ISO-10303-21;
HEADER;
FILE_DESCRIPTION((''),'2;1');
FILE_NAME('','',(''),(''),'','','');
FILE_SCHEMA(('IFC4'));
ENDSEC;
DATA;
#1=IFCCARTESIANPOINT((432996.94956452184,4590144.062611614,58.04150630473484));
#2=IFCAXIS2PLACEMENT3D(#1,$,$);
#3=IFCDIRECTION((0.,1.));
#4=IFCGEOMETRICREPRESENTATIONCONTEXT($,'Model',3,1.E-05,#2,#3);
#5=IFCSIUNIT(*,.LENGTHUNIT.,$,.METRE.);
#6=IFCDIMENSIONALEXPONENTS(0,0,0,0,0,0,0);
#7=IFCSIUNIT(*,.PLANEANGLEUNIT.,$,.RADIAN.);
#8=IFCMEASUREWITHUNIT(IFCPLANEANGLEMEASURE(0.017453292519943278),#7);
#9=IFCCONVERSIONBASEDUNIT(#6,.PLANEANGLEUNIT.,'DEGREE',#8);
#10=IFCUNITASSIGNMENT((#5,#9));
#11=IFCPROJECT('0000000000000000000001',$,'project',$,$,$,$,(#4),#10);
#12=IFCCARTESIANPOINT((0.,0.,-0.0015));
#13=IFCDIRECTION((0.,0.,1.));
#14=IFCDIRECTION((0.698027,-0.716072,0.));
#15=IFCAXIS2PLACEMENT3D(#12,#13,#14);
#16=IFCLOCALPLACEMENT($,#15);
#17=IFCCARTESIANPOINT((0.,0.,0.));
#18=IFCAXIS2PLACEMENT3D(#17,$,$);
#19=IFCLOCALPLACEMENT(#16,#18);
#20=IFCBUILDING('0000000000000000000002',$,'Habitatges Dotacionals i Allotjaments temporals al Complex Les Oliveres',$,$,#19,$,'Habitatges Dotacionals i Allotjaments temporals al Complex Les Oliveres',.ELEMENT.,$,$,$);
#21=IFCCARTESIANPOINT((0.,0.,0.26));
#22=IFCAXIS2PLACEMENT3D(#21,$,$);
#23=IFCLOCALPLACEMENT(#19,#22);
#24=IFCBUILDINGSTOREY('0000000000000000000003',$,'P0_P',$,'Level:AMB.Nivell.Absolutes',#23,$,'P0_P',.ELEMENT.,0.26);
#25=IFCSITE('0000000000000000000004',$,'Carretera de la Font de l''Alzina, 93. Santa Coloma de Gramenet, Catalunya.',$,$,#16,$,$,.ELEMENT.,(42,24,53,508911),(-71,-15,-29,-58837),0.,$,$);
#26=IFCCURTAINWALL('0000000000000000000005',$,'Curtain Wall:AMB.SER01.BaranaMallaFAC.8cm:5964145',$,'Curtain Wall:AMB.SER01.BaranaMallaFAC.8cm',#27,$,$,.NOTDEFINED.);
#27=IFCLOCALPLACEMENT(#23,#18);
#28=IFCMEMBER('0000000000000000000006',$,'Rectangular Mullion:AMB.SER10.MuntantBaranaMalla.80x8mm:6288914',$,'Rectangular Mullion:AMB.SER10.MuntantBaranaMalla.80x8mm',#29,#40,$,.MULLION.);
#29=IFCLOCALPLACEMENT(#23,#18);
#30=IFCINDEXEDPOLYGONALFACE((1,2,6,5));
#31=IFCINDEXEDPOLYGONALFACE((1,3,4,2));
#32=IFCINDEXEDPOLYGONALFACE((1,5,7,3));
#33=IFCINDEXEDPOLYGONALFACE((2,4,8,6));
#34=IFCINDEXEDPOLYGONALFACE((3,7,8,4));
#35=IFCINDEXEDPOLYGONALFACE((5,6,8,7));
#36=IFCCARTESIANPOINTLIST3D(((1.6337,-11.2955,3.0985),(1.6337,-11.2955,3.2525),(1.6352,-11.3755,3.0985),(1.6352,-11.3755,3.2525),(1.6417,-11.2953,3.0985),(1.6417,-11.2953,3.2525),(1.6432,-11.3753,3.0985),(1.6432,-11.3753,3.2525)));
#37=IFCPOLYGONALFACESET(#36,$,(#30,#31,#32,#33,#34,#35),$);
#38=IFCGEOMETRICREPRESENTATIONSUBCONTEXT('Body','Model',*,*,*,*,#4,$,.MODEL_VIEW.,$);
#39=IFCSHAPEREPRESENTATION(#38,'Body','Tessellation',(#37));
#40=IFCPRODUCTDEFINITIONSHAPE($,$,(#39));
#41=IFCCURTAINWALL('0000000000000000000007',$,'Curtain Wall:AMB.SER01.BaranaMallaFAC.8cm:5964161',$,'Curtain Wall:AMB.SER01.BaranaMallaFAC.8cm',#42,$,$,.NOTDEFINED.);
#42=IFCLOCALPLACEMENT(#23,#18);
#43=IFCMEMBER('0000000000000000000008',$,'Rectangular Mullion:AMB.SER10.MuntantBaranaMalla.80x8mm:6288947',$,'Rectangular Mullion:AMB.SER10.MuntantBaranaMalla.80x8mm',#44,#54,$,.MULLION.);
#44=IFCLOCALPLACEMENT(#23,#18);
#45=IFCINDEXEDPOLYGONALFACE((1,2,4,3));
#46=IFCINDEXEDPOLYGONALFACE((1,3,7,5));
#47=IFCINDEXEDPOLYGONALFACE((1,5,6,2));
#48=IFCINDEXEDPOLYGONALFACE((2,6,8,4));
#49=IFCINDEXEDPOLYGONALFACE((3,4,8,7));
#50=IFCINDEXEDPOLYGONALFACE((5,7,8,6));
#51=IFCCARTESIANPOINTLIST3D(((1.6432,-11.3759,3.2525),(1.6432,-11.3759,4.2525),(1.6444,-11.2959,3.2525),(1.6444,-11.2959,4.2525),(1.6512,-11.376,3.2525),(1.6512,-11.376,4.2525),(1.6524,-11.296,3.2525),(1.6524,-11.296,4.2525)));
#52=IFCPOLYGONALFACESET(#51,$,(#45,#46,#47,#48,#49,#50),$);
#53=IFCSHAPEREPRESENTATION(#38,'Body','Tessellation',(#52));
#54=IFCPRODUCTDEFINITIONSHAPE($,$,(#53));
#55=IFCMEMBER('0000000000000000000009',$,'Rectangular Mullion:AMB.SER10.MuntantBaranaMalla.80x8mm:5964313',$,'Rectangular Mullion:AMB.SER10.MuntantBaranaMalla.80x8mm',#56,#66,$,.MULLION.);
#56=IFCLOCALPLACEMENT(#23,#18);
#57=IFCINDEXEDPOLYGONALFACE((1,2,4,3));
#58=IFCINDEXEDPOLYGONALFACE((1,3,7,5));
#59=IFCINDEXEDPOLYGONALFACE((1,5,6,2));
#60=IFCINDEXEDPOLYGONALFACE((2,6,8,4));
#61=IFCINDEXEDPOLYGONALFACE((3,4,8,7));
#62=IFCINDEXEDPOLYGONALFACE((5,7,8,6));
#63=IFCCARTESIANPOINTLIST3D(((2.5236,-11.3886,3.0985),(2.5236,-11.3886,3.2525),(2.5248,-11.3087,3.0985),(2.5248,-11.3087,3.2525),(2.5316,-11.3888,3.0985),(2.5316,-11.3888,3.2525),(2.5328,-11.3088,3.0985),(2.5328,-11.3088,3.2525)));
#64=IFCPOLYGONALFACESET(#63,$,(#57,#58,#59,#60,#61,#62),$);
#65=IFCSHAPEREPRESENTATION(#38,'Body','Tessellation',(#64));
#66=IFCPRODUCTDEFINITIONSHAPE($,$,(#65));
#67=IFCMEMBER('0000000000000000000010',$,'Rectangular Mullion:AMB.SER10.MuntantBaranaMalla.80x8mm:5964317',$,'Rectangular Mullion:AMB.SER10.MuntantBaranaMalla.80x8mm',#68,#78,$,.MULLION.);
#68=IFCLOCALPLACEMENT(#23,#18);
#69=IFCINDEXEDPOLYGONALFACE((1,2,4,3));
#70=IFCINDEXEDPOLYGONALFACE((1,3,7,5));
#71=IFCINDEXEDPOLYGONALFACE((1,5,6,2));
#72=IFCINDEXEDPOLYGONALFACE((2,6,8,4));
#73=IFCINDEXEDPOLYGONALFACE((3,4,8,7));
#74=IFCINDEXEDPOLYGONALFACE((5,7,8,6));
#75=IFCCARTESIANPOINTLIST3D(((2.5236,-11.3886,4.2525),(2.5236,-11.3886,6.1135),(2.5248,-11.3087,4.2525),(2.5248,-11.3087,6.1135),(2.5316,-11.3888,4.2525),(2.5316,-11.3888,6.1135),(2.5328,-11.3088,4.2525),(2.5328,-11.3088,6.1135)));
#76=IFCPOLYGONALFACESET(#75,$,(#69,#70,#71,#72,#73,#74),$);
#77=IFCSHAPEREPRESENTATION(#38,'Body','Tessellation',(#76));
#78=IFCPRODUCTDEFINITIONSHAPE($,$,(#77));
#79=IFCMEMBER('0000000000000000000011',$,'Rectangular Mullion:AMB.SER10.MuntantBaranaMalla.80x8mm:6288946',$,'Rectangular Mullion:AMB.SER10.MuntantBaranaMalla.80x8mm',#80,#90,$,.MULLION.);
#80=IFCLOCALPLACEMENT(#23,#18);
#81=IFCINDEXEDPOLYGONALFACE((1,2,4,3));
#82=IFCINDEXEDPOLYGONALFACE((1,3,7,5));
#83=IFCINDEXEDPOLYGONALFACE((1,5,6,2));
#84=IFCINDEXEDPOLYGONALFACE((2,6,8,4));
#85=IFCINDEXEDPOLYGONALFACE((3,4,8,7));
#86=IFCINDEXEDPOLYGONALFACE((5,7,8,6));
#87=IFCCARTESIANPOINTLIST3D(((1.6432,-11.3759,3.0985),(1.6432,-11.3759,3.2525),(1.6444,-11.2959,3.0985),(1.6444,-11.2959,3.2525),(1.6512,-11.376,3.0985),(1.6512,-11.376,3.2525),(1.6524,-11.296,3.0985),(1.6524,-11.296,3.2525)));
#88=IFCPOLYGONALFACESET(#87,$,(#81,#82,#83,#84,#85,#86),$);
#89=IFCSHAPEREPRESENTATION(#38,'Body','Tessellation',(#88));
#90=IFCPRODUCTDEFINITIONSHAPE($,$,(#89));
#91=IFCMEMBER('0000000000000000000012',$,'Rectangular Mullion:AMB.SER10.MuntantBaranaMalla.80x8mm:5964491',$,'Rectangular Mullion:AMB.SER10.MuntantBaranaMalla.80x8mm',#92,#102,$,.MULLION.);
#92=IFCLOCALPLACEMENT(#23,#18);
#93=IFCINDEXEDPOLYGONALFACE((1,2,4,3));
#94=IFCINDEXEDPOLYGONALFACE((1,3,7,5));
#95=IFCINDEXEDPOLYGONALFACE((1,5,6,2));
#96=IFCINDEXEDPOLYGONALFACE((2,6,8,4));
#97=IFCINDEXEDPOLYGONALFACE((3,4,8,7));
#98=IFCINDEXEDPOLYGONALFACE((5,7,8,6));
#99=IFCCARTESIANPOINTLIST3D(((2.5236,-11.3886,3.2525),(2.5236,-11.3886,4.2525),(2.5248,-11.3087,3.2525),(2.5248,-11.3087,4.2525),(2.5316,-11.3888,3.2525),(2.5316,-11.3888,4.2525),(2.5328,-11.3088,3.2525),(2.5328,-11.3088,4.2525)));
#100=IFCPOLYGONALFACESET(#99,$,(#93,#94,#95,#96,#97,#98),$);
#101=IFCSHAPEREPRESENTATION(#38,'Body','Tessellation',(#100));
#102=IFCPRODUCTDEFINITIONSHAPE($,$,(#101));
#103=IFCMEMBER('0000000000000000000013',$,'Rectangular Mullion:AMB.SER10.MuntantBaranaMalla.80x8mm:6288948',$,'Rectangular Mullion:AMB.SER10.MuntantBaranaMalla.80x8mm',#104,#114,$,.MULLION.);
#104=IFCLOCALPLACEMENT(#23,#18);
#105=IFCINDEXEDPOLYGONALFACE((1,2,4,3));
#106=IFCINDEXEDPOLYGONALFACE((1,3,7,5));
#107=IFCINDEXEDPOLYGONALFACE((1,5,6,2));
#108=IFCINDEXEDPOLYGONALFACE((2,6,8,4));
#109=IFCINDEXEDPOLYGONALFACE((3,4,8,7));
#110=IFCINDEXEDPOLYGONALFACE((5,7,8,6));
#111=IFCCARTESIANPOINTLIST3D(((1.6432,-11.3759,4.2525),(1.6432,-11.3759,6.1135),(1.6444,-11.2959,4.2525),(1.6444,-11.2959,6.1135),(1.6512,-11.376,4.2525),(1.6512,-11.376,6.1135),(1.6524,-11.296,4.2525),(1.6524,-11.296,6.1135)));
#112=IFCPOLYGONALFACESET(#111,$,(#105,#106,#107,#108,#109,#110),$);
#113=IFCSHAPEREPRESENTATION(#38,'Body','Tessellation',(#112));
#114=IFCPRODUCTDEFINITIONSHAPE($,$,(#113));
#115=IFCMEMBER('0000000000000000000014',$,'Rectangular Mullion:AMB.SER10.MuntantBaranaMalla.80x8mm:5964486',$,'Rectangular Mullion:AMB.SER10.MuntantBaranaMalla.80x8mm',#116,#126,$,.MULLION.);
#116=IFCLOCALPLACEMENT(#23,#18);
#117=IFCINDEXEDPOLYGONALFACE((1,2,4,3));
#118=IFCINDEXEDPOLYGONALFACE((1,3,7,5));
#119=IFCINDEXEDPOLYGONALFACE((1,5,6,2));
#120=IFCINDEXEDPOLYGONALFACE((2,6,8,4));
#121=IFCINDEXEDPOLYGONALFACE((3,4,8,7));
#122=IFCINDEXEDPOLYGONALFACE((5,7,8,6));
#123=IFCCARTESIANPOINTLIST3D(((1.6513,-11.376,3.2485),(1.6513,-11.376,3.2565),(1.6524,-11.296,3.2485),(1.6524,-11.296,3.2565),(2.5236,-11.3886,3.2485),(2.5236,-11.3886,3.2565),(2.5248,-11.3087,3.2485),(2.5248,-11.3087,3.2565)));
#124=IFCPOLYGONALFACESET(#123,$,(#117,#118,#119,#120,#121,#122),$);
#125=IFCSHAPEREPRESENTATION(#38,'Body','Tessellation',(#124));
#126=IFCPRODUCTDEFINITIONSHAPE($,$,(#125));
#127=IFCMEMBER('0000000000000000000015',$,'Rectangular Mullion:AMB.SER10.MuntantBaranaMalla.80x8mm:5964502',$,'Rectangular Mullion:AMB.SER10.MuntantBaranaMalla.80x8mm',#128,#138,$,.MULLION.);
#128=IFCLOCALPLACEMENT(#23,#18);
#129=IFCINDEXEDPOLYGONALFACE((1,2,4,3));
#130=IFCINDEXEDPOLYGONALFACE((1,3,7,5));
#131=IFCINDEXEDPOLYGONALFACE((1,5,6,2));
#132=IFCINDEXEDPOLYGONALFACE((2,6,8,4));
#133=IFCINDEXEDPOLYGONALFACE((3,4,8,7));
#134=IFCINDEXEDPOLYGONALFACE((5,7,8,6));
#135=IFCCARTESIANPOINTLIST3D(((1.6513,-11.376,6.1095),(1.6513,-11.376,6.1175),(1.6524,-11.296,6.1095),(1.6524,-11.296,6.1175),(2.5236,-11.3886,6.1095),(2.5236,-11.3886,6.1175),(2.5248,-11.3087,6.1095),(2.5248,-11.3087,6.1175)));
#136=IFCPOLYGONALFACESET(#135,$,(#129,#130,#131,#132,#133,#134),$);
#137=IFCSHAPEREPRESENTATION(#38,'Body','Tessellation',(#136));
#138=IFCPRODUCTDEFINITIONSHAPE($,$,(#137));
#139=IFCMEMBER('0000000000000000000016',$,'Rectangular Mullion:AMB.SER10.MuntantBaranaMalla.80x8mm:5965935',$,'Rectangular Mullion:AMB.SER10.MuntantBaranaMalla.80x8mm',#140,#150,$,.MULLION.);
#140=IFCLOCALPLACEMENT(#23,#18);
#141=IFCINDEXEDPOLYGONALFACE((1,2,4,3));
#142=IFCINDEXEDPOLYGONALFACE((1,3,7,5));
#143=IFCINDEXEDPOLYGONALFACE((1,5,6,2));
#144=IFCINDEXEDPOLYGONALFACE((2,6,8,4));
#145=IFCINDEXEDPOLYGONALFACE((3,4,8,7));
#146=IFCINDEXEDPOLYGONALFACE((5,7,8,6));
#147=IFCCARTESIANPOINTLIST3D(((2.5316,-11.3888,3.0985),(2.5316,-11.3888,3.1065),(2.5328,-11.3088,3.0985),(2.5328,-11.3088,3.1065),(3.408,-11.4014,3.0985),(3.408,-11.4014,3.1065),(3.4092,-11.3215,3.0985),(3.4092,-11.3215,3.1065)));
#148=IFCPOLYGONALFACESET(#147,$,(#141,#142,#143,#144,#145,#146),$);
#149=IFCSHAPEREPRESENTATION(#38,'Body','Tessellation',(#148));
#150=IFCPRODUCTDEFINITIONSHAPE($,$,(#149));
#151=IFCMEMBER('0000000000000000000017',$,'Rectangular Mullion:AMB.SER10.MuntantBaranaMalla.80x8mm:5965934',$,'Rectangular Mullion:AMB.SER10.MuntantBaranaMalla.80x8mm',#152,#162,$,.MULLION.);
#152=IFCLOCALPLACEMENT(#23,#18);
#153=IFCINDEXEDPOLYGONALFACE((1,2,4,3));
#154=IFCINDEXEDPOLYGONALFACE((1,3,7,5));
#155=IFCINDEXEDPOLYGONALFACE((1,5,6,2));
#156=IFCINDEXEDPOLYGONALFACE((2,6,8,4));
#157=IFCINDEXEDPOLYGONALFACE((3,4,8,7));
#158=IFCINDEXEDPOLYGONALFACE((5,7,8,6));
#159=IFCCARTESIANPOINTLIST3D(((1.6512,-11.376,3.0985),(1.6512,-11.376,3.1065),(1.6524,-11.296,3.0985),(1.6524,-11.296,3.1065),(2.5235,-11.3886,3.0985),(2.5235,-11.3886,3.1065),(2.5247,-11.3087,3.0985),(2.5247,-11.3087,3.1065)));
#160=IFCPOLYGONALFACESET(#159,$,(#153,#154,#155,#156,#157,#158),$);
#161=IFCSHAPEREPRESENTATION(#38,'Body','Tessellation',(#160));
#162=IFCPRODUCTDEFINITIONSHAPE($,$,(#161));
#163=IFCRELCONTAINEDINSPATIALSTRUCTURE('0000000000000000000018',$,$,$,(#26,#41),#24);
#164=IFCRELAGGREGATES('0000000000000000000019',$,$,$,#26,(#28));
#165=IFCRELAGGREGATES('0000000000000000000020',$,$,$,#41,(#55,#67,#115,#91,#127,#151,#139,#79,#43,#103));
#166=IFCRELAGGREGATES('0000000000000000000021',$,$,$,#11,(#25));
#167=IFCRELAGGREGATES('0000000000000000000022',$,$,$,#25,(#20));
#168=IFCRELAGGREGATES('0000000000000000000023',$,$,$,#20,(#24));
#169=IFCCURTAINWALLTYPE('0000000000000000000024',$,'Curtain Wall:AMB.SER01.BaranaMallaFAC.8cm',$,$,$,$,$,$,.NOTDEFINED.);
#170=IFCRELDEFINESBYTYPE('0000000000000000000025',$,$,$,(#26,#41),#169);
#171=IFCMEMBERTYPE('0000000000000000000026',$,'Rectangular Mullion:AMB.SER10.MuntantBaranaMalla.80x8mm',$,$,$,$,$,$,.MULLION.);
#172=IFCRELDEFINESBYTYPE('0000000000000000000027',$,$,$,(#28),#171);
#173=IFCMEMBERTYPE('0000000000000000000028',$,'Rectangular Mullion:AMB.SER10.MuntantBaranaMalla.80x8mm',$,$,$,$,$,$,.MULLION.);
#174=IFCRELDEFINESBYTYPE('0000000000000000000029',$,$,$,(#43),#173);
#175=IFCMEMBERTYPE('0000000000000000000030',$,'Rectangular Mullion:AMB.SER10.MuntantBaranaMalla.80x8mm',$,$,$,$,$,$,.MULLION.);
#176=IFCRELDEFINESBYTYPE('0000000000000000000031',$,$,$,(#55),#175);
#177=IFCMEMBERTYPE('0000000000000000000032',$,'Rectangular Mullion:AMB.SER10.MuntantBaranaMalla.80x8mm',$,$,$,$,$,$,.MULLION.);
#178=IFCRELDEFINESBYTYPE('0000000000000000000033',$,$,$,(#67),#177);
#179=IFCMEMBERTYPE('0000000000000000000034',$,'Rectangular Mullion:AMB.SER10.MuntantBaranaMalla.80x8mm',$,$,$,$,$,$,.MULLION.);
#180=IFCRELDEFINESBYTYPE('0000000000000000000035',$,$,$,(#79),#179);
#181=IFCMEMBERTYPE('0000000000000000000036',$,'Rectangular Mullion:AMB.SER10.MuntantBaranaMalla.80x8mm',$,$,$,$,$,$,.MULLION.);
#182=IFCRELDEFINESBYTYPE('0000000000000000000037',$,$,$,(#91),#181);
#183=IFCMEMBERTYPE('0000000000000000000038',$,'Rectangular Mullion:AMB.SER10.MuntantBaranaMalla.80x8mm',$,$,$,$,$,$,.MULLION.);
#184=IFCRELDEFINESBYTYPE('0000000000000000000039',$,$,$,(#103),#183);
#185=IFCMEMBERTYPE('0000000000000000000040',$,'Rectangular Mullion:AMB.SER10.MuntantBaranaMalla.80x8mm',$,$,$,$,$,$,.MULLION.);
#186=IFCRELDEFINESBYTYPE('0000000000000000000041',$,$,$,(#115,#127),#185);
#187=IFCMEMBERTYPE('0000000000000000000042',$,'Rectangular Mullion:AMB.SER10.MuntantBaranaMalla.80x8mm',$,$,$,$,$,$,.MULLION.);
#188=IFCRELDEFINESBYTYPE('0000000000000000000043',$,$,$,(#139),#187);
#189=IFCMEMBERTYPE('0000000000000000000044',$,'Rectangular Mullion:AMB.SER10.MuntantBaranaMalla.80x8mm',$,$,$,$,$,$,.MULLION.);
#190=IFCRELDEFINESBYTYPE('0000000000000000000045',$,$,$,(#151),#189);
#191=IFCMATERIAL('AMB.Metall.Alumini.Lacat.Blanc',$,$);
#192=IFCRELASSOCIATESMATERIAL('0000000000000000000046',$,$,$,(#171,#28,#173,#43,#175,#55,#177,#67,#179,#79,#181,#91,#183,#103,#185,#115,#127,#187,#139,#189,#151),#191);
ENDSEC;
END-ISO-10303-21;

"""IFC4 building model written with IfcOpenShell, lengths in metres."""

from ifc_helpers import new_model, entity, si_unit, converted_unit, direction, frame, origin, place, context, subcontext, project, spatial, indexed_curve, outline, extrude, source, transform, mapped, material, type_object, type_shapes, element, aggregate, save


model = new_model("IFC4")

# Units and contexts
model_context = context("Model", 3, precision=1e-05, world=frame((432996.94956452184, 4590144.062611614, 58.04150630473484)), true_north=direction((0.0, 1.0)))
body_context = subcontext(model_context, "Body", "Model", "MODEL_VIEW")
ifc_project = project(units=[si_unit("LENGTHUNIT", "METRE"), converted_unit("PLANEANGLEUNIT", "DEGREE", entity("IfcPlaneAngleMeasure", 0.017453292519943278), si_unit("PLANEANGLEUNIT", "RADIAN"), dimensions=[0, 0, 0, 0, 0, 0, 0])], contexts=[model_context])

# Site, building, storey
site_placement = place(None, frame((0.0, 0.0, -0.0015), z_axis=(0.0, 0.0, 1.0), x_axis=(0.698027, -0.716072, 0.0)))
site = spatial("IfcSite", under=ifc_project, at=site_placement, Name="Carretera de la Font de l'Alzina, 93. Santa Coloma de Gramenet, Catalunya.", CompositionType="ELEMENT", RefLatitude=(42, 24, 53, 508911), RefLongitude=(-71, -15, -29, -58837), RefElevation=0.0)
building_placement = place(site_placement, origin())
building = spatial("IfcBuilding", under=site, at=building_placement, Name="Habitatges Dotacionals i Allotjaments temporals al Complex Les Oliveres", LongName="Habitatges Dotacionals i Allotjaments temporals al Complex Les Oliveres", CompositionType="ELEMENT")
storey_placement = place(building_placement, frame((0.0, 0.0, 0.26)))
storey = spatial("IfcBuildingStorey", under=building, at=storey_placement, Name="P0_P", ObjectType="Level:AMB.Nivell.Absolutes", LongName="P0_P", CompositionType="ELEMENT", Elevation=0.26)

# Curtain wall, member
curtain_wall_type_1 = type_object("IfcCurtainWallType", Name="Curtain Wall:AMB.SER01.BaranaMallaFAC.8cm", PredefinedType="NOTDEFINED")
curtain_wall_1_placement = place(storey_placement, frame((0.0, 0.0, -0.26)))
curtain_wall_1 = element("IfcCurtainWall", 1, at=curtain_wall_1_placement, inside=storey, type_object=curtain_wall_type_1, Name="Curtain Wall:AMB.SER01.BaranaMallaFAC.8cm:5964145", ObjectType="Curtain Wall:AMB.SER01.BaranaMallaFAC.8cm", PredefinedType="NOTDEFINED")
ifc_material_1 = material(Name="AMB.Metall.Alumini.Lacat.Blanc")
member_type_1 = type_object("IfcMemberType", Name="Rectangular Mullion:AMB.SER10.MuntantBaranaMalla.80x8mm", PredefinedType="MULLION", material=ifc_material_1)
shared_shape_1 = source(origin(), body_context, "Body", "SweptSolid", [
    extrude(outline(indexed_curve([(-0.004, -0.04), (0.004, -0.04), (0.004, 0.04), (-0.004, 0.04), (-0.004, -0.04)], self_intersect=False)), frame((-0.004, -0.04, -0.154), z_axis=(0.0, 0.0, 1.0), x_axis=(-1.0, 0.0, 0.0)), (0.0, 0.0, 1.0), 0.154),
])
type_shapes(member_type_1, [shared_shape_1])
member_1_placement = place(curtain_wall_1_placement, frame((1.6432, -11.3753, 3.3585), z_axis=(0.0, 0.0, -1.0), x_axis=(0.999822, 0.018842, 0.0)))
member_1 = element("IfcMember", 2, at=member_1_placement, type_object=member_type_1, material=ifc_material_1, Name="Rectangular Mullion:AMB.SER10.MuntantBaranaMalla.80x8mm:6288914", ObjectType="Rectangular Mullion:AMB.SER10.MuntantBaranaMalla.80x8mm", PredefinedType="MULLION", context=body_context, shape_type="MappedRepresentation", body=[
    mapped(shared_shape_1, transform((0.0, 0.0, 0.0), scale=1.0)),
])

# Curtain wall, members
curtain_wall_2_placement = place(storey_placement, frame((0.0, 0.0, -0.26)))
curtain_wall_2 = element("IfcCurtainWall", 3, at=curtain_wall_2_placement, inside=storey, type_object=curtain_wall_type_1, Name="Curtain Wall:AMB.SER01.BaranaMallaFAC.8cm:5964161", ObjectType="Curtain Wall:AMB.SER01.BaranaMallaFAC.8cm", PredefinedType="NOTDEFINED")
member_type_2 = type_object("IfcMemberType", Name="Rectangular Mullion:AMB.SER10.MuntantBaranaMalla.80x8mm", PredefinedType="MULLION", material=ifc_material_1)
shared_shape_2 = source(origin(), body_context, "Body", "SweptSolid", [
    extrude(outline(indexed_curve([(-0.004, -0.04), (0.004, -0.04), (0.004, 0.04), (-0.004, 0.04), (-0.004, -0.04)], self_intersect=False)), frame((-0.004, -0.04, -1.0), z_axis=(0.0, 0.0, 1.0), x_axis=(-1.0, 0.0, 0.0)), (0.0, 0.0, 1.0), 1.0),
])
type_shapes(member_type_2, [shared_shape_2])
member_2_placement = place(curtain_wall_2_placement, frame((1.6432, -11.3759, 4.5125), z_axis=(0.0, 0.0, 1.0), x_axis=(-0.999895, 0.014473, 0.0)))
member_2 = element("IfcMember", 4, at=member_2_placement, type_object=member_type_2, material=ifc_material_1, Name="Rectangular Mullion:AMB.SER10.MuntantBaranaMalla.80x8mm:6288947", ObjectType="Rectangular Mullion:AMB.SER10.MuntantBaranaMalla.80x8mm", PredefinedType="MULLION", context=body_context, shape_type="MappedRepresentation", body=[
    mapped(shared_shape_2, transform((0.0, 0.0, 0.0), scale=1.0)),
])
member_type_3 = type_object("IfcMemberType", Name="Rectangular Mullion:AMB.SER10.MuntantBaranaMalla.80x8mm", PredefinedType="MULLION", material=ifc_material_1)
shared_shape_3 = source(origin(), body_context, "Body", "SweptSolid", [
    extrude(outline(indexed_curve([(-0.004, -0.04), (0.004, -0.04), (0.004, 0.04), (-0.004, 0.04), (-0.004, -0.04)], self_intersect=False)), frame((0.0, -0.04, -0.154), z_axis=(0.0, 0.0, 1.0), x_axis=(-1.0, 0.0, 0.0)), (0.0, 0.0, 1.0), 0.154),
])
type_shapes(member_type_3, [shared_shape_3])
member_3_placement = place(curtain_wall_2_placement, frame((2.5276, -11.3887, 3.3585), z_axis=(0.0, 0.0, -1.0), x_axis=(0.999895, -0.014473, 0.0)))
member_3 = element("IfcMember", 5, at=member_3_placement, type_object=member_type_3, material=ifc_material_1, Name="Rectangular Mullion:AMB.SER10.MuntantBaranaMalla.80x8mm:5964313", ObjectType="Rectangular Mullion:AMB.SER10.MuntantBaranaMalla.80x8mm", PredefinedType="MULLION", context=body_context, shape_type="MappedRepresentation", body=[
    mapped(shared_shape_3, transform((0.0, 0.0, 0.0), scale=1.0)),
])
member_type_4 = type_object("IfcMemberType", Name="Rectangular Mullion:AMB.SER10.MuntantBaranaMalla.80x8mm", PredefinedType="MULLION", material=ifc_material_1)
shared_shape_4 = source(origin(), body_context, "Body", "SweptSolid", [
    extrude(outline(indexed_curve([(-0.004, -0.04), (0.004, -0.04), (0.004, 0.04), (-0.004, 0.04), (-0.004, -0.04)], self_intersect=False)), frame((0.0, -0.04, -1.861), z_axis=(0.0, 0.0, 1.0), x_axis=(-1.0, 0.0, 0.0)), (0.0, 0.0, 1.0), 1.861),
])
type_shapes(member_type_4, [shared_shape_4])
member_4_placement = place(curtain_wall_2_placement, frame((2.5276, -11.3887, 4.5125), z_axis=(0.0, 0.0, -1.0), x_axis=(0.999895, -0.014473, 0.0)))
member_4 = element("IfcMember", 6, at=member_4_placement, type_object=member_type_4, material=ifc_material_1, Name="Rectangular Mullion:AMB.SER10.MuntantBaranaMalla.80x8mm:5964317", ObjectType="Rectangular Mullion:AMB.SER10.MuntantBaranaMalla.80x8mm", PredefinedType="MULLION", context=body_context, shape_type="MappedRepresentation", body=[
    mapped(shared_shape_4, transform((0.0, 0.0, 0.0), scale=1.0)),
])
member_type_5 = type_object("IfcMemberType", Name="Rectangular Mullion:AMB.SER10.MuntantBaranaMalla.80x8mm", PredefinedType="MULLION", material=ifc_material_1)
shared_shape_5 = source(origin(), body_context, "Body", "SweptSolid", [
    extrude(outline(indexed_curve([(-0.004, -0.04), (0.004, -0.04), (0.004, 0.04), (-0.004, 0.04), (-0.004, -0.04)], self_intersect=False)), frame((-0.004, -0.04, -0.154), z_axis=(0.0, 0.0, 1.0), x_axis=(-1.0, 0.0, 0.0)), (0.0, 0.0, 1.0), 0.154),
])
type_shapes(member_type_5, [shared_shape_5])
member_5_placement = place(curtain_wall_2_placement, frame((1.6432, -11.3759, 3.5125), z_axis=(0.0, 0.0, 1.0), x_axis=(-0.999895, 0.014473, 0.0)))
member_5 = element("IfcMember", 7, at=member_5_placement, type_object=member_type_5, material=ifc_material_1, Name="Rectangular Mullion:AMB.SER10.MuntantBaranaMalla.80x8mm:6288946", ObjectType="Rectangular Mullion:AMB.SER10.MuntantBaranaMalla.80x8mm", PredefinedType="MULLION", context=body_context, shape_type="MappedRepresentation", body=[
    mapped(shared_shape_5, transform((0.0, 0.0, 0.0), scale=1.0)),
])
member_type_6 = type_object("IfcMemberType", Name="Rectangular Mullion:AMB.SER10.MuntantBaranaMalla.80x8mm", PredefinedType="MULLION", material=ifc_material_1)
shared_shape_6 = source(origin(), body_context, "Body", "SweptSolid", [
    extrude(outline(indexed_curve([(-0.004, -0.04), (0.004, -0.04), (0.004, 0.04), (-0.004, 0.04), (-0.004, -0.04)], self_intersect=False)), frame((0.0, -0.04, -1.0), z_axis=(0.0, 0.0, 1.0), x_axis=(-1.0, 0.0, 0.0)), (0.0, 0.0, 1.0), 1.0),
])
type_shapes(member_type_6, [shared_shape_6])
member_6_placement = place(curtain_wall_2_placement, frame((2.5276, -11.3887, 3.5125), z_axis=(0.0, 0.0, -1.0), x_axis=(0.999895, -0.014473, 0.0)))
member_6 = element("IfcMember", 8, at=member_6_placement, type_object=member_type_6, material=ifc_material_1, Name="Rectangular Mullion:AMB.SER10.MuntantBaranaMalla.80x8mm:5964491", ObjectType="Rectangular Mullion:AMB.SER10.MuntantBaranaMalla.80x8mm", PredefinedType="MULLION", context=body_context, shape_type="MappedRepresentation", body=[
    mapped(shared_shape_6, transform((0.0, 0.0, 0.0), scale=1.0)),
])
member_type_7 = type_object("IfcMemberType", Name="Rectangular Mullion:AMB.SER10.MuntantBaranaMalla.80x8mm", PredefinedType="MULLION", material=ifc_material_1)
shared_shape_7 = source(origin(), body_context, "Body", "SweptSolid", [
    extrude(outline(indexed_curve([(-0.004, -0.04), (0.004, -0.04), (0.004, 0.04), (-0.004, 0.04), (-0.004, -0.04)], self_intersect=False)), frame((-0.004, -0.04, -1.861), z_axis=(0.0, 0.0, 1.0), x_axis=(-1.0, 0.0, 0.0)), (0.0, 0.0, 1.0), 1.861),
])
type_shapes(member_type_7, [shared_shape_7])
member_7_placement = place(curtain_wall_2_placement, frame((1.6432, -11.3759, 6.3735), z_axis=(0.0, 0.0, 1.0), x_axis=(-0.999895, 0.014473, 0.0)))
member_7 = element("IfcMember", 9, at=member_7_placement, type_object=member_type_7, material=ifc_material_1, Name="Rectangular Mullion:AMB.SER10.MuntantBaranaMalla.80x8mm:6288948", ObjectType="Rectangular Mullion:AMB.SER10.MuntantBaranaMalla.80x8mm", PredefinedType="MULLION", context=body_context, shape_type="MappedRepresentation", body=[
    mapped(shared_shape_7, transform((0.0, 0.0, 0.0), scale=1.0)),
])
member_type_8 = type_object("IfcMemberType", Name="Rectangular Mullion:AMB.SER10.MuntantBaranaMalla.80x8mm", PredefinedType="MULLION", material=ifc_material_1)
shared_shape_8 = source(origin(), body_context, "Body", "SweptSolid", [
    extrude(outline(indexed_curve([(-0.004, -0.04), (0.004, -0.04), (0.004, 0.04), (-0.004, 0.04), (-0.004, -0.04)], self_intersect=False)), frame((0.0, -0.04, -0.8724), z_axis=(0.0, 0.0, 1.0), x_axis=(-1.0, 0.0, 0.0)), (0.0, 0.0, 1.0), 0.8724),
])
type_shapes(member_type_8, [shared_shape_8])
member_8_placement = place(curtain_wall_2_placement, frame((2.5236, -11.3886, 3.5125), z_axis=(0.999895, -0.014473, 0.0), x_axis=(0.0, 0.0, 1.0)))
member_8 = element("IfcMember", 10, at=member_8_placement, type_object=member_type_8, material=ifc_material_1, Name="Rectangular Mullion:AMB.SER10.MuntantBaranaMalla.80x8mm:5964486", ObjectType="Rectangular Mullion:AMB.SER10.MuntantBaranaMalla.80x8mm", PredefinedType="MULLION", context=body_context, shape_type="MappedRepresentation", body=[
    mapped(shared_shape_8, transform((0.0, 0.0, 0.0), scale=1.0)),
])
member_9_placement = place(curtain_wall_2_placement, frame((2.5236, -11.3886, 6.3735), z_axis=(0.999895, -0.014473, 0.0), x_axis=(0.0, 0.0, 1.0)))
member_9 = element("IfcMember", 11, at=member_9_placement, type_object=member_type_8, material=ifc_material_1, Name="Rectangular Mullion:AMB.SER10.MuntantBaranaMalla.80x8mm:5964502", ObjectType="Rectangular Mullion:AMB.SER10.MuntantBaranaMalla.80x8mm", PredefinedType="MULLION", context=body_context, shape_type="MappedRepresentation", body=[
    mapped(shared_shape_8, transform((0.0, 0.0, 0.0), scale=1.0)),
])
member_type_9 = type_object("IfcMemberType", Name="Rectangular Mullion:AMB.SER10.MuntantBaranaMalla.80x8mm", PredefinedType="MULLION", material=ifc_material_1)
shared_shape_9 = source(origin(), body_context, "Body", "SweptSolid", [
    extrude(outline(indexed_curve([(-0.004, -0.04), (0.004, -0.04), (0.004, 0.04), (-0.004, 0.04), (-0.004, -0.04)], self_intersect=False)), frame((-0.004, -0.04, -0.8765), z_axis=(0.0, 0.0, 1.0), x_axis=(-1.0, 0.0, 0.0)), (0.0, 0.0, 1.0), 0.8765),
])
type_shapes(member_type_9, [shared_shape_9])
member_10_placement = place(curtain_wall_2_placement, frame((2.5316, -11.3888, 3.3585), z_axis=(-0.999895, 0.014473, 0.0), x_axis=(0.0, 0.0, -1.0)))
member_10 = element("IfcMember", 12, at=member_10_placement, type_object=member_type_9, material=ifc_material_1, Name="Rectangular Mullion:AMB.SER10.MuntantBaranaMalla.80x8mm:5965935", ObjectType="Rectangular Mullion:AMB.SER10.MuntantBaranaMalla.80x8mm", PredefinedType="MULLION", context=body_context, shape_type="MappedRepresentation", body=[
    mapped(shared_shape_9, transform((0.0, 0.0, 0.0), scale=1.0)),
])
member_type_10 = type_object("IfcMemberType", Name="Rectangular Mullion:AMB.SER10.MuntantBaranaMalla.80x8mm", PredefinedType="MULLION", material=ifc_material_1)
shared_shape_10 = source(origin(), body_context, "Body", "SweptSolid", [
    extrude(outline(indexed_curve([(-0.004, -0.04), (0.004, -0.04), (0.004, 0.04), (-0.004, 0.04), (-0.004, -0.04)], self_intersect=False)), frame((-0.004, -0.04, -0.8724), z_axis=(0.0, 0.0, 1.0), x_axis=(-1.0, 0.0, 0.0)), (0.0, 0.0, 1.0), 0.8724),
])
type_shapes(member_type_10, [shared_shape_10])
member_11_placement = place(curtain_wall_2_placement, frame((1.6512, -11.376, 3.3585), z_axis=(-0.999895, 0.014473, 0.0), x_axis=(0.0, 0.0, -1.0)))
member_11 = element("IfcMember", 13, at=member_11_placement, type_object=member_type_10, material=ifc_material_1, Name="Rectangular Mullion:AMB.SER10.MuntantBaranaMalla.80x8mm:5965934", ObjectType="Rectangular Mullion:AMB.SER10.MuntantBaranaMalla.80x8mm", PredefinedType="MULLION", context=body_context, shape_type="MappedRepresentation", body=[
    mapped(shared_shape_10, transform((0.0, 0.0, 0.0), scale=1.0)),
])

aggregate(curtain_wall_1, [member_1])

aggregate(curtain_wall_2, [member_3, member_4, member_8, member_6, member_9, member_11, member_10, member_5, member_2, member_7])

save(model, "model.ifc")
